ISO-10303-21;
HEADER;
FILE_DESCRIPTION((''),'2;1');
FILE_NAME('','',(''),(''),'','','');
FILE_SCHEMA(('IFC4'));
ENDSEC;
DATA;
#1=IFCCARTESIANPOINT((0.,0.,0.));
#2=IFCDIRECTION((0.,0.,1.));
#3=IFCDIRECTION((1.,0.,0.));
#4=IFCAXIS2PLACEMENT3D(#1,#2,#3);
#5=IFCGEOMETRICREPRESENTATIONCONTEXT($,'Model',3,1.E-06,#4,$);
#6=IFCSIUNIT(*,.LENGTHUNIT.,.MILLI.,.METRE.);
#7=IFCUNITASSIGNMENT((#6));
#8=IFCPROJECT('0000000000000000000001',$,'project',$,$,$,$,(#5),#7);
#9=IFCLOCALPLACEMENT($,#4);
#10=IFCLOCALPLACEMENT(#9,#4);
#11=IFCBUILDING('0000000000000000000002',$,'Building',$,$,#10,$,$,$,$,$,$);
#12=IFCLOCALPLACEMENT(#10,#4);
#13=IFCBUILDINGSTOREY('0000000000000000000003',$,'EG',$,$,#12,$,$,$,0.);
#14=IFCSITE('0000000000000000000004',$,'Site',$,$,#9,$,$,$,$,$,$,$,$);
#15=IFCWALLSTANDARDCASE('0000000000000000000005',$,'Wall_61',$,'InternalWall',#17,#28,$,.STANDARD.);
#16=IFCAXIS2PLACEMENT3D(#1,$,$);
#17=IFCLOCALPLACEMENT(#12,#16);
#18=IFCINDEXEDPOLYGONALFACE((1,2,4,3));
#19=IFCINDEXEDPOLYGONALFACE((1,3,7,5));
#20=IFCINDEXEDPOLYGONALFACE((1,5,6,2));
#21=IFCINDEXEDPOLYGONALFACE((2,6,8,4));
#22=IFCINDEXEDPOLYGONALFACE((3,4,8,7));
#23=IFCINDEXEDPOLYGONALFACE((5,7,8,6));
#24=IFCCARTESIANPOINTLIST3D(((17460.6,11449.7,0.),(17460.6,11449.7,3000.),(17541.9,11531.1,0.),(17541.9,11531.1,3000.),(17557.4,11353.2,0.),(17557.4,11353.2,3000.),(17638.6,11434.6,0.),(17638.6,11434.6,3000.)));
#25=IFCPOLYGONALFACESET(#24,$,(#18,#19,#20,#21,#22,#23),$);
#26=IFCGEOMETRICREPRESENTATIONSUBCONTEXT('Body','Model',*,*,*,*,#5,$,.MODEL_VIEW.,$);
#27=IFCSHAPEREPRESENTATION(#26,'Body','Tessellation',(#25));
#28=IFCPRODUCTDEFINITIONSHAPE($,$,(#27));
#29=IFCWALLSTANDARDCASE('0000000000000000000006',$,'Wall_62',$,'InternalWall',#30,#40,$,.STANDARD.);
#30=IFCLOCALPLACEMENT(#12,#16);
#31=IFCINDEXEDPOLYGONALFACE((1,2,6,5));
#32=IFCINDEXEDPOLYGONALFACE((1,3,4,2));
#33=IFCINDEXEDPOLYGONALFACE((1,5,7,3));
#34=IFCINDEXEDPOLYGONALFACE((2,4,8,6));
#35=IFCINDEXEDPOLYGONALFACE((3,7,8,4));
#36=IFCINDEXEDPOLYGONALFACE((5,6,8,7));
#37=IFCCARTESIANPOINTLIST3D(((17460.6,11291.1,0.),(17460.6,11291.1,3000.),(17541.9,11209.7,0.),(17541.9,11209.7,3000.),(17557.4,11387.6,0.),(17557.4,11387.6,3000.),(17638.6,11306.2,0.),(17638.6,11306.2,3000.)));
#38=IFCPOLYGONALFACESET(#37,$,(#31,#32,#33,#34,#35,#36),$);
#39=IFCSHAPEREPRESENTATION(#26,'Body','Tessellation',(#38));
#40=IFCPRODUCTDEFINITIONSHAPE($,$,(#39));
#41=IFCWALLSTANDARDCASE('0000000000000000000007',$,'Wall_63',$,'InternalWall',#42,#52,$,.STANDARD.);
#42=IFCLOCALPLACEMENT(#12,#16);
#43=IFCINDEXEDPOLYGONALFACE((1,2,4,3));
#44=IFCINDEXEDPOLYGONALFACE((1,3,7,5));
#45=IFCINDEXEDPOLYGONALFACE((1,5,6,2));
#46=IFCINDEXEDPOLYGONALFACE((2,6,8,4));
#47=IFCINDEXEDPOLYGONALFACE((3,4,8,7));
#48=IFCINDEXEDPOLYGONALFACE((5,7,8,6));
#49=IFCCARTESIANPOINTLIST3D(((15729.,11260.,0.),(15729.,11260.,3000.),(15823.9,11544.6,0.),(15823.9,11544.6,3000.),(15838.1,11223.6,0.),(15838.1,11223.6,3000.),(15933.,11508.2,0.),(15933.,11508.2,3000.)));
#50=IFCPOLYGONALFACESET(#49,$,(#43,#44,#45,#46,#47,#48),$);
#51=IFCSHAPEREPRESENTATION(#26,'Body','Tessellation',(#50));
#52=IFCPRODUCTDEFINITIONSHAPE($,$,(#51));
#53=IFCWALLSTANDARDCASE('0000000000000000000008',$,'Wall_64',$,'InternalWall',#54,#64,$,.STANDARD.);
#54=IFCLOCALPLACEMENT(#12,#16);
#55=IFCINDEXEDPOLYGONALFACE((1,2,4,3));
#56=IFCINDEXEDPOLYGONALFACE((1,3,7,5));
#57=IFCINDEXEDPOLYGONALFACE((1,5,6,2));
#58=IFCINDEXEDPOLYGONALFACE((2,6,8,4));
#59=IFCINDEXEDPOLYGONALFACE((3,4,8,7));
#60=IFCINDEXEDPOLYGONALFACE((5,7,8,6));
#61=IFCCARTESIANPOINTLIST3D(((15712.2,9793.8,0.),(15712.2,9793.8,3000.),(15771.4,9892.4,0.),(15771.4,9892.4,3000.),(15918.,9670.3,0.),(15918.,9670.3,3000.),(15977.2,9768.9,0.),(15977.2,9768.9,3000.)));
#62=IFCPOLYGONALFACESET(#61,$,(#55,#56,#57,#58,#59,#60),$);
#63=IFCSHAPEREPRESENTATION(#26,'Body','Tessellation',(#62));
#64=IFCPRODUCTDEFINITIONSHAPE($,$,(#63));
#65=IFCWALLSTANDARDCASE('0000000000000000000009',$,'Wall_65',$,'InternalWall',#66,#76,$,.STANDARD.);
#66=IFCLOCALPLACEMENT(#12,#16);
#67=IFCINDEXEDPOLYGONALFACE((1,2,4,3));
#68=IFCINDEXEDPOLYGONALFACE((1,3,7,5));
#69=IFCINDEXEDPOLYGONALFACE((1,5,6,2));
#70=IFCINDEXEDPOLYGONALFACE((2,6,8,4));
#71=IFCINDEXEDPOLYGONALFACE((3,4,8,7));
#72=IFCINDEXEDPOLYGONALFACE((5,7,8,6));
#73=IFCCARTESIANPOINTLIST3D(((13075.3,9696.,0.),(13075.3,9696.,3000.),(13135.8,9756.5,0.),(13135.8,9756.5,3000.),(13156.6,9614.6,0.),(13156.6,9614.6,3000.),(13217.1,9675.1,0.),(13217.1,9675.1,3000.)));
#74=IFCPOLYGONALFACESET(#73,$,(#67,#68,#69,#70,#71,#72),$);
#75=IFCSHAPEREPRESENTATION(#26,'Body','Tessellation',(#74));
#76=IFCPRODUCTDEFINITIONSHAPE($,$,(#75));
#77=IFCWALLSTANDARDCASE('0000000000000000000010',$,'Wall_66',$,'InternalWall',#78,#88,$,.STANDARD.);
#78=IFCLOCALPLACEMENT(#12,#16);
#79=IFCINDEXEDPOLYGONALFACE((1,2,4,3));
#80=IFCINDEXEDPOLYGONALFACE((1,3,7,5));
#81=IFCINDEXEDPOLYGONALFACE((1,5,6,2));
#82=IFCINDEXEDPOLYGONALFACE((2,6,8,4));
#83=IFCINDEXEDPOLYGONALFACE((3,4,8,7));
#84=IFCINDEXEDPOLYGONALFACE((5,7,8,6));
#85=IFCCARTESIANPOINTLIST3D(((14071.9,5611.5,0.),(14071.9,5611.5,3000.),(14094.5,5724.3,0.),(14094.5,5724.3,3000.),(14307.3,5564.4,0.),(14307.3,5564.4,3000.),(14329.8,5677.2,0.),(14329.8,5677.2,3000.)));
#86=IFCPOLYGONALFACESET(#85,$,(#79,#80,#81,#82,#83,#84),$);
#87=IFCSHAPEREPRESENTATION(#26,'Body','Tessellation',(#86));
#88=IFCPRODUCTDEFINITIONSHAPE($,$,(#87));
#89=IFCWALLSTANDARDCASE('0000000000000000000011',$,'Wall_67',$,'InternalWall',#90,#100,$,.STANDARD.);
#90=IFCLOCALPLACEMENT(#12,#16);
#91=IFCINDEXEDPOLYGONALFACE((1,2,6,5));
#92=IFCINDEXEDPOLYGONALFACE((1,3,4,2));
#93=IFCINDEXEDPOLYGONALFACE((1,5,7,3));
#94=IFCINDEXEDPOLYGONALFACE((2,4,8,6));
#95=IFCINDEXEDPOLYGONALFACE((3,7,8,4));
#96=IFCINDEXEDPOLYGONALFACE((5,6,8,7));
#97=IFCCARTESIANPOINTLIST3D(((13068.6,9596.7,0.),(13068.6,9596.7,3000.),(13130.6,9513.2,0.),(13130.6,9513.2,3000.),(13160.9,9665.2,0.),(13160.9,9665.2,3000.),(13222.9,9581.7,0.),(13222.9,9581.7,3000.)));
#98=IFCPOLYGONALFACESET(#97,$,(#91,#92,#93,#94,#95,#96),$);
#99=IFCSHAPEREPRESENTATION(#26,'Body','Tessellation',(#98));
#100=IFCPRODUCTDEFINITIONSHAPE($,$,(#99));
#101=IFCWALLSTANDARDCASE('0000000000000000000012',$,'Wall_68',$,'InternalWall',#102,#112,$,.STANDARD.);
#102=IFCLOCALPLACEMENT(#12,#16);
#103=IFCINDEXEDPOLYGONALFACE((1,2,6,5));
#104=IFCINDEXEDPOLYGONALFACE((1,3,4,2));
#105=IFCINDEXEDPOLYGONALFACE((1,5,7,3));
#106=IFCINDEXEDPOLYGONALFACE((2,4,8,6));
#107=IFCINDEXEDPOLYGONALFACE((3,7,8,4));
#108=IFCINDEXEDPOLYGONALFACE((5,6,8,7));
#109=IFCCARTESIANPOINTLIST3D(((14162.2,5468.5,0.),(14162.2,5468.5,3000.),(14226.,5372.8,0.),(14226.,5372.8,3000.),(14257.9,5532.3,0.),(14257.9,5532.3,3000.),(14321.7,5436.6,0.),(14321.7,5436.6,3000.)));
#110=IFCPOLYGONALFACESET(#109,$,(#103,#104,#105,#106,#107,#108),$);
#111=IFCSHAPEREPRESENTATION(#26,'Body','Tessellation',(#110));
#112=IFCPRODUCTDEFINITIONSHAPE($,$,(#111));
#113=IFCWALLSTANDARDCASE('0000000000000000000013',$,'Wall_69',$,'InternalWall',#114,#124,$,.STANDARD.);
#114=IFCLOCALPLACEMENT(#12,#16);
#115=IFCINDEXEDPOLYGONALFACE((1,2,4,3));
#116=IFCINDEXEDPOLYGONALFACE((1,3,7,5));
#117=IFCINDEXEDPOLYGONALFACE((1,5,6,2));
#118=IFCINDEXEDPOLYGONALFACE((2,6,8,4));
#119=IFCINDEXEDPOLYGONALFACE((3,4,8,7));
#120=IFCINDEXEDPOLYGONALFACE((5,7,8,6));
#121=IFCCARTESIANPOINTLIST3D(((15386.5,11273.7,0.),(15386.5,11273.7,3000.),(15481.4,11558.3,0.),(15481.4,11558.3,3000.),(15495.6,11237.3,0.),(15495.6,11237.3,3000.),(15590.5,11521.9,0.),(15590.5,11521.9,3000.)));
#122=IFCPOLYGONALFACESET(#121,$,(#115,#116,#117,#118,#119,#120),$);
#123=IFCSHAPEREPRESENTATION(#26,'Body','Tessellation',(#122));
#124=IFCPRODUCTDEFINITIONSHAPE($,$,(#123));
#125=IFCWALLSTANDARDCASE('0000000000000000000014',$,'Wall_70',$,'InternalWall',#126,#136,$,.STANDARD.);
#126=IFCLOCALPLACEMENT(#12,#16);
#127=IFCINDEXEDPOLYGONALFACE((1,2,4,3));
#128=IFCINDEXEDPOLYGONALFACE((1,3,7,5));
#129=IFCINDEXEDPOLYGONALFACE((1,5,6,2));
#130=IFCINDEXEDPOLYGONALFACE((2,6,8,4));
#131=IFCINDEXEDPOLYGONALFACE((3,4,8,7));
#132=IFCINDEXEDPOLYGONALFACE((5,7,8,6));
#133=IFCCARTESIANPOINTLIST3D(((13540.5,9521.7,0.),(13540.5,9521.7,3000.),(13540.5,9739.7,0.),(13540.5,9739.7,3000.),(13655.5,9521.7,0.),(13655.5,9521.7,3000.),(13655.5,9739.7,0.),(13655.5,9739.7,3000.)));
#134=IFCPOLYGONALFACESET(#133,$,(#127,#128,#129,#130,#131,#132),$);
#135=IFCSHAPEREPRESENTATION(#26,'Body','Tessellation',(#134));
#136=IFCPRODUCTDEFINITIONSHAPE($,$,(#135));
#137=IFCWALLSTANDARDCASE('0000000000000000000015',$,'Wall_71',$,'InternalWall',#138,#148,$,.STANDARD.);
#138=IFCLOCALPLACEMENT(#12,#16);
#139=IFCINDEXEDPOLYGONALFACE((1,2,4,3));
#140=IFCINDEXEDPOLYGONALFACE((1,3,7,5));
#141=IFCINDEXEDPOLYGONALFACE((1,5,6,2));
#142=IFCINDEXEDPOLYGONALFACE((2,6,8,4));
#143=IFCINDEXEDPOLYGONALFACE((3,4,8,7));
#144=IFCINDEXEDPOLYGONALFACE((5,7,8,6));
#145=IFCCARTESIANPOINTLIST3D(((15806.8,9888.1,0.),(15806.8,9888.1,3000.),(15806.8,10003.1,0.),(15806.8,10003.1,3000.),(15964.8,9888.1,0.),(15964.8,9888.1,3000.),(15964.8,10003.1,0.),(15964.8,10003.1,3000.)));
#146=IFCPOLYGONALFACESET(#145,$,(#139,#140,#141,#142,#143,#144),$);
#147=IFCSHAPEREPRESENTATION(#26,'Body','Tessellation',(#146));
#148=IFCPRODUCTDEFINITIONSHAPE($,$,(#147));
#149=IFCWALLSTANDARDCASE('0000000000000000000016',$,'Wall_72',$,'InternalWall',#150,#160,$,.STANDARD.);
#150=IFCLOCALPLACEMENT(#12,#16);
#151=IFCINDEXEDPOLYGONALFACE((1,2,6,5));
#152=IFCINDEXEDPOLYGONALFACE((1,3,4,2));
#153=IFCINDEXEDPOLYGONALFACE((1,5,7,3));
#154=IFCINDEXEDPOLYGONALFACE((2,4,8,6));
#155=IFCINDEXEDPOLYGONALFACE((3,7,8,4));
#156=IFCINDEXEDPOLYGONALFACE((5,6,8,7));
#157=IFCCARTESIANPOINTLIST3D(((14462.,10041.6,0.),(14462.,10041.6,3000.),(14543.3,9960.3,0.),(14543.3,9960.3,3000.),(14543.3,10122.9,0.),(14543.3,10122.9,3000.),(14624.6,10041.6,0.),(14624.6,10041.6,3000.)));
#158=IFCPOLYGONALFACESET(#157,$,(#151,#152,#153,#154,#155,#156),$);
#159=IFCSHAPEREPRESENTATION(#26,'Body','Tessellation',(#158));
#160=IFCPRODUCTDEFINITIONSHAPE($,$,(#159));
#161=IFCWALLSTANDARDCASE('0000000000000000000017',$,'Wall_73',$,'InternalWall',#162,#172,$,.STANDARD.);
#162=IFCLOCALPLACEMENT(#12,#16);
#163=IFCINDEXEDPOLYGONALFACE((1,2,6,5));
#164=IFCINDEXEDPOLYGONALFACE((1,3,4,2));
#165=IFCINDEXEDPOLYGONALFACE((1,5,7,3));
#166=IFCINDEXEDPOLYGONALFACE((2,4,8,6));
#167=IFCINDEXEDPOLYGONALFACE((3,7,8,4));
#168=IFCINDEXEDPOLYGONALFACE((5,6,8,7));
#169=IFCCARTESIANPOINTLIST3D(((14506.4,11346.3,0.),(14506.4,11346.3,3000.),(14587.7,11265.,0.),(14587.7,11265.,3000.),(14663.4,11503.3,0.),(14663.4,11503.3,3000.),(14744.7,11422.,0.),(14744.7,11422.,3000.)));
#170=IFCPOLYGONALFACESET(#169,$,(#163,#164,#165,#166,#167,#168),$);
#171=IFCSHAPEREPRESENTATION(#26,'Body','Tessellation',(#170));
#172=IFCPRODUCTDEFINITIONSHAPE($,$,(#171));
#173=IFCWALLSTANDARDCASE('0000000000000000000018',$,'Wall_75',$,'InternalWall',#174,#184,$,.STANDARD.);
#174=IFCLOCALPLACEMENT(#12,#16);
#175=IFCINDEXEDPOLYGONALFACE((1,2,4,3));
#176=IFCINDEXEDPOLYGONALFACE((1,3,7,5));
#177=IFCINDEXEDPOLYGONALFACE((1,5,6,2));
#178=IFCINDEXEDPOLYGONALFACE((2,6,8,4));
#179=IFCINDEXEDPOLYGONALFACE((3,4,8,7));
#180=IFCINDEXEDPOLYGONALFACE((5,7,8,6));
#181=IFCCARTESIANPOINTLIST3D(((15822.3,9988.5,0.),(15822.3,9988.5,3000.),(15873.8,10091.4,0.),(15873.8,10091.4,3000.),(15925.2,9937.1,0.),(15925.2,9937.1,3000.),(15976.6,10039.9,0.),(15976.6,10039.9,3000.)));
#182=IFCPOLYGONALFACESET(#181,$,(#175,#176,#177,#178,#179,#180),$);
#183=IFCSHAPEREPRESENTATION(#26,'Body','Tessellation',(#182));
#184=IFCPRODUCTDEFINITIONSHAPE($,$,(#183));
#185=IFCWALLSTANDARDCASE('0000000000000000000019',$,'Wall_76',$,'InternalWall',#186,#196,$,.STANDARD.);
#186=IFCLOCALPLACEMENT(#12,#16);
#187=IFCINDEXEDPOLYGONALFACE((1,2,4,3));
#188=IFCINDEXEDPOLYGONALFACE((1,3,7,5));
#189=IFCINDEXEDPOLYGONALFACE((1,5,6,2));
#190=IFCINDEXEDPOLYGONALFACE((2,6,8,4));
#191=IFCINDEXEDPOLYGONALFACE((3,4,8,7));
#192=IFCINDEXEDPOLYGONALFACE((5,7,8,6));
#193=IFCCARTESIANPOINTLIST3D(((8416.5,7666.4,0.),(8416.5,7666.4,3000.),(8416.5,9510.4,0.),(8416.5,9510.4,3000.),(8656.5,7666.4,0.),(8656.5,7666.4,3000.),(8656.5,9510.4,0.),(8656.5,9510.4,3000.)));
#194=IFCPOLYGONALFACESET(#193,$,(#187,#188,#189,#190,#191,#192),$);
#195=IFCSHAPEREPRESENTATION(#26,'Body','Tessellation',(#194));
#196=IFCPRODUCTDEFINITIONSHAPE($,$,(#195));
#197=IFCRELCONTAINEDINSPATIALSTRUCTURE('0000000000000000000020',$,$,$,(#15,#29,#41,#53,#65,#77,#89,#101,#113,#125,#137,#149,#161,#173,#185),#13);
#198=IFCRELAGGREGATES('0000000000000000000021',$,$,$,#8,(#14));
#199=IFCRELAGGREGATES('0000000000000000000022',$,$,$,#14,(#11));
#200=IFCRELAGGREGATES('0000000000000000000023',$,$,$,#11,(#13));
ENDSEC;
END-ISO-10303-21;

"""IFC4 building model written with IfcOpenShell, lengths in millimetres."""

from ifc_helpers import new_model, si_unit, frame, origin_with_axes, place, context, subcontext, project, spatial, rectangle, extrude, element, save


model = new_model("IFC4")

# Units and contexts
model_context = context("Model", 3, precision=1e-06, world=origin_with_axes())
body_context = subcontext(model_context, "Body", "Model", "MODEL_VIEW")
ifc_project = project(units=[si_unit("LENGTHUNIT", "METRE", prefix="MILLI")], contexts=[model_context])

# Site, building, storey
site_placement = place(None, origin_with_axes())
site = spatial("IfcSite", under=ifc_project, at=site_placement, Name="Site")
building_placement = place(site_placement, origin_with_axes())
building = spatial("IfcBuilding", under=site, at=building_placement, Name="Building")
storey_placement = place(building_placement, origin_with_axes())
storey = spatial("IfcBuildingStorey", under=building, at=storey_placement, Name="EG", Elevation=0.0)

# Walls
wall_1_placement = place(storey_placement, origin_with_axes())
element("IfcWallStandardCase", 1, at=wall_1_placement, inside=storey, Name="Wall_61", ObjectType="InternalWall", PredefinedType="STANDARD", context=body_context, shape_type="SweptSolid", body=[
    extrude(rectangle(XDim=136.6, YDim=115.0), frame((17549.6, 11442.1, 0.0), z_axis=(0.0, 0.0, 1.0), x_axis=(-0.708021, 0.706191, 0.0)), (0.0, 0.0, 1.0), 3000.0),
])
wall_2_placement = place(storey_placement, origin_with_axes())
element("IfcWallStandardCase", 2, at=wall_2_placement, inside=storey, Name="Wall_62", ObjectType="InternalWall", PredefinedType="STANDARD", context=body_context, shape_type="SweptSolid", body=[
    extrude(rectangle(XDim=136.6, YDim=115.0), frame((17549.6, 11298.6, 0.0), z_axis=(0.0, 0.0, 1.0), x_axis=(-0.708021, -0.706191, 0.0)), (0.0, 0.0, 1.0), 3000.0),
])
wall_3_placement = place(storey_placement, origin_with_axes())
element("IfcWallStandardCase", 3, at=wall_3_placement, inside=storey, Name="Wall_63", ObjectType="InternalWall", PredefinedType="STANDARD", context=body_context, shape_type="SweptSolid", body=[
    extrude(rectangle(XDim=300.0, YDim=115.0), frame((15831.0, 11384.1, 0.0), z_axis=(0.0, 0.0, 1.0), x_axis=(-0.316228, -0.948683, 0.0)), (0.0, 0.0, 1.0), 3000.0),
])
wall_4_placement = place(storey_placement, origin_with_axes())
element("IfcWallStandardCase", 4, at=wall_4_placement, inside=storey, Name="Wall_64", ObjectType="InternalWall", PredefinedType="STANDARD", context=body_context, shape_type="SweptSolid", body=[
    extrude(rectangle(XDim=240.0, YDim=115.0), frame((15844.7, 9781.3, 0.0), z_axis=(0.0, 0.0, 1.0), x_axis=(-0.857493, 0.514496, 0.0)), (0.0, 0.0, 1.0), 3000.0),
])
wall_5_placement = place(storey_placement, origin_with_axes())
element("IfcWallStandardCase", 5, at=wall_5_placement, inside=storey, Name="Wall_65", ObjectType="InternalWall", PredefinedType="STANDARD", context=body_context, shape_type="SweptSolid", body=[
    extrude(rectangle(XDim=85.6, YDim=115.0), frame((13146.2, 9685.5, 0.0), z_axis=(0.0, 0.0, 1.0), x_axis=(-0.707107, -0.707107, 0.0)), (0.0, 0.0, 1.0), 3000.0),
])
wall_6_placement = place(storey_placement, origin_with_axes())
element("IfcWallStandardCase", 6, at=wall_6_placement, inside=storey, Name="Wall_66", ObjectType="InternalWall", PredefinedType="STANDARD", context=body_context, shape_type="SweptSolid", body=[
    extrude(rectangle(XDim=240.0, YDim=115.0), frame((14200.9, 5644.3, 0.0), z_axis=(0.0, 0.0, 1.0), x_axis=(-0.980581, 0.196116, 0.0)), (0.0, 0.0, 1.0), 3000.0),
])
wall_7_placement = place(storey_placement, origin_with_axes())
element("IfcWallStandardCase", 7, at=wall_7_placement, inside=storey, Name="Wall_67", ObjectType="InternalWall", PredefinedType="STANDARD", context=body_context, shape_type="SweptSolid", body=[
    extrude(rectangle(XDim=104.0, YDim=115.0), frame((13145.8, 9589.2, 0.0), z_axis=(0.0, 0.0, 1.0), x_axis=(0.596147, -0.802875, 0.0)), (0.0, 0.0, 1.0), 3000.0),
])
wall_8_placement = place(storey_placement, origin_with_axes())
element("IfcWallStandardCase", 8, at=wall_8_placement, inside=storey, Name="Wall_68", ObjectType="InternalWall", PredefinedType="STANDARD", context=body_context, shape_type="SweptSolid", body=[
    extrude(rectangle(XDim=115.0, YDim=115.0), frame((14242.0, 5452.6, 0.0), z_axis=(0.0, 0.0, 1.0), x_axis=(0.83205, 0.5547, 0.0)), (0.0, 0.0, 1.0), 3000.0),
])
wall_9_placement = place(storey_placement, origin_with_axes())
element("IfcWallStandardCase", 9, at=wall_9_placement, inside=storey, Name="Wall_69", ObjectType="InternalWall", PredefinedType="STANDARD", context=body_context, shape_type="SweptSolid", body=[
    extrude(rectangle(XDim=300.0, YDim=115.0), frame((15488.5, 11397.8, 0.0), z_axis=(0.0, 0.0, 1.0), x_axis=(0.316228, 0.948683, 0.0)), (0.0, 0.0, 1.0), 3000.0),
])
wall_10_placement = place(storey_placement, origin_with_axes())
element("IfcWallStandardCase", 10, at=wall_10_placement, inside=storey, Name="Wall_70", ObjectType="InternalWall", PredefinedType="STANDARD", context=body_context, shape_type="SweptSolid", body=[
    extrude(rectangle(XDim=218.0, YDim=115.0), frame((13598.0, 9630.7, 0.0), z_axis=(0.0, 0.0, 1.0), x_axis=(0.0, -1.0, 0.0)), (0.0, 0.0, 1.0), 3000.0),
])
wall_11_placement = place(storey_placement, origin_with_axes())
element("IfcWallStandardCase", 11, at=wall_11_placement, inside=storey, Name="Wall_71", ObjectType="InternalWall", PredefinedType="STANDARD", context=body_context, shape_type="SweptSolid", body=[
    extrude(rectangle(XDim=158.0, YDim=115.0), frame((15885.8, 9945.6, 0.0), z_axis=(0.0, 0.0, 1.0), x_axis=(-1.0, 0.0, 0.0)), (0.0, 0.0, 1.0), 3000.0),
])
wall_12_placement = place(storey_placement, origin_with_axes())
element("IfcWallStandardCase", 12, at=wall_12_placement, inside=storey, Name="Wall_72", ObjectType="InternalWall", PredefinedType="STANDARD", context=body_context, shape_type="SweptSolid", body=[
    extrude(rectangle(XDim=115.0, YDim=115.0), frame((14543.3, 10041.6, 0.0), z_axis=(0.0, 0.0, 1.0), x_axis=(-0.707107, 0.707107, 0.0)), (0.0, 0.0, 1.0), 3000.0),
])
wall_13_placement = place(storey_placement, origin_with_axes())
element("IfcWallStandardCase", 13, at=wall_13_placement, inside=storey, Name="Wall_73", ObjectType="InternalWall", PredefinedType="STANDARD", context=body_context, shape_type="SweptSolid", body=[
    extrude(rectangle(XDim=222.0, YDim=115.0), frame((14625.6, 11384.1, 0.0), z_axis=(0.0, 0.0, 1.0), x_axis=(-0.707107, -0.707107, 0.0)), (0.0, 0.0, 1.0), 3000.0),
])

# Walls
wall_14_placement = place(storey_placement, origin_with_axes())
element("IfcWallStandardCase", 14, at=wall_14_placement, inside=storey, Name="Wall_75", ObjectType="InternalWall", PredefinedType="STANDARD", context=body_context, shape_type="SweptSolid", body=[
    extrude(rectangle(XDim=115.0, YDim=115.0), frame((15899.5, 10014.2, 0.0), z_axis=(0.0, 0.0, 1.0), x_axis=(-0.894427, 0.447214, 0.0)), (0.0, 0.0, 1.0), 3000.0),
])
wall_15_placement = place(storey_placement, origin_with_axes())
element("IfcWallStandardCase", 15, at=wall_15_placement, inside=storey, Name="Wall_76", ObjectType="InternalWall", PredefinedType="STANDARD", context=body_context, shape_type="SweptSolid", body=[
    extrude(rectangle(XDim=1844.0, YDim=240.0), frame((8536.5, 8588.4, 0.0), z_axis=(0.0, 0.0, 1.0), x_axis=(0.0, -1.0, 0.0)), (0.0, 0.0, 1.0), 3000.0),
])

save(model, "model.ifc")
